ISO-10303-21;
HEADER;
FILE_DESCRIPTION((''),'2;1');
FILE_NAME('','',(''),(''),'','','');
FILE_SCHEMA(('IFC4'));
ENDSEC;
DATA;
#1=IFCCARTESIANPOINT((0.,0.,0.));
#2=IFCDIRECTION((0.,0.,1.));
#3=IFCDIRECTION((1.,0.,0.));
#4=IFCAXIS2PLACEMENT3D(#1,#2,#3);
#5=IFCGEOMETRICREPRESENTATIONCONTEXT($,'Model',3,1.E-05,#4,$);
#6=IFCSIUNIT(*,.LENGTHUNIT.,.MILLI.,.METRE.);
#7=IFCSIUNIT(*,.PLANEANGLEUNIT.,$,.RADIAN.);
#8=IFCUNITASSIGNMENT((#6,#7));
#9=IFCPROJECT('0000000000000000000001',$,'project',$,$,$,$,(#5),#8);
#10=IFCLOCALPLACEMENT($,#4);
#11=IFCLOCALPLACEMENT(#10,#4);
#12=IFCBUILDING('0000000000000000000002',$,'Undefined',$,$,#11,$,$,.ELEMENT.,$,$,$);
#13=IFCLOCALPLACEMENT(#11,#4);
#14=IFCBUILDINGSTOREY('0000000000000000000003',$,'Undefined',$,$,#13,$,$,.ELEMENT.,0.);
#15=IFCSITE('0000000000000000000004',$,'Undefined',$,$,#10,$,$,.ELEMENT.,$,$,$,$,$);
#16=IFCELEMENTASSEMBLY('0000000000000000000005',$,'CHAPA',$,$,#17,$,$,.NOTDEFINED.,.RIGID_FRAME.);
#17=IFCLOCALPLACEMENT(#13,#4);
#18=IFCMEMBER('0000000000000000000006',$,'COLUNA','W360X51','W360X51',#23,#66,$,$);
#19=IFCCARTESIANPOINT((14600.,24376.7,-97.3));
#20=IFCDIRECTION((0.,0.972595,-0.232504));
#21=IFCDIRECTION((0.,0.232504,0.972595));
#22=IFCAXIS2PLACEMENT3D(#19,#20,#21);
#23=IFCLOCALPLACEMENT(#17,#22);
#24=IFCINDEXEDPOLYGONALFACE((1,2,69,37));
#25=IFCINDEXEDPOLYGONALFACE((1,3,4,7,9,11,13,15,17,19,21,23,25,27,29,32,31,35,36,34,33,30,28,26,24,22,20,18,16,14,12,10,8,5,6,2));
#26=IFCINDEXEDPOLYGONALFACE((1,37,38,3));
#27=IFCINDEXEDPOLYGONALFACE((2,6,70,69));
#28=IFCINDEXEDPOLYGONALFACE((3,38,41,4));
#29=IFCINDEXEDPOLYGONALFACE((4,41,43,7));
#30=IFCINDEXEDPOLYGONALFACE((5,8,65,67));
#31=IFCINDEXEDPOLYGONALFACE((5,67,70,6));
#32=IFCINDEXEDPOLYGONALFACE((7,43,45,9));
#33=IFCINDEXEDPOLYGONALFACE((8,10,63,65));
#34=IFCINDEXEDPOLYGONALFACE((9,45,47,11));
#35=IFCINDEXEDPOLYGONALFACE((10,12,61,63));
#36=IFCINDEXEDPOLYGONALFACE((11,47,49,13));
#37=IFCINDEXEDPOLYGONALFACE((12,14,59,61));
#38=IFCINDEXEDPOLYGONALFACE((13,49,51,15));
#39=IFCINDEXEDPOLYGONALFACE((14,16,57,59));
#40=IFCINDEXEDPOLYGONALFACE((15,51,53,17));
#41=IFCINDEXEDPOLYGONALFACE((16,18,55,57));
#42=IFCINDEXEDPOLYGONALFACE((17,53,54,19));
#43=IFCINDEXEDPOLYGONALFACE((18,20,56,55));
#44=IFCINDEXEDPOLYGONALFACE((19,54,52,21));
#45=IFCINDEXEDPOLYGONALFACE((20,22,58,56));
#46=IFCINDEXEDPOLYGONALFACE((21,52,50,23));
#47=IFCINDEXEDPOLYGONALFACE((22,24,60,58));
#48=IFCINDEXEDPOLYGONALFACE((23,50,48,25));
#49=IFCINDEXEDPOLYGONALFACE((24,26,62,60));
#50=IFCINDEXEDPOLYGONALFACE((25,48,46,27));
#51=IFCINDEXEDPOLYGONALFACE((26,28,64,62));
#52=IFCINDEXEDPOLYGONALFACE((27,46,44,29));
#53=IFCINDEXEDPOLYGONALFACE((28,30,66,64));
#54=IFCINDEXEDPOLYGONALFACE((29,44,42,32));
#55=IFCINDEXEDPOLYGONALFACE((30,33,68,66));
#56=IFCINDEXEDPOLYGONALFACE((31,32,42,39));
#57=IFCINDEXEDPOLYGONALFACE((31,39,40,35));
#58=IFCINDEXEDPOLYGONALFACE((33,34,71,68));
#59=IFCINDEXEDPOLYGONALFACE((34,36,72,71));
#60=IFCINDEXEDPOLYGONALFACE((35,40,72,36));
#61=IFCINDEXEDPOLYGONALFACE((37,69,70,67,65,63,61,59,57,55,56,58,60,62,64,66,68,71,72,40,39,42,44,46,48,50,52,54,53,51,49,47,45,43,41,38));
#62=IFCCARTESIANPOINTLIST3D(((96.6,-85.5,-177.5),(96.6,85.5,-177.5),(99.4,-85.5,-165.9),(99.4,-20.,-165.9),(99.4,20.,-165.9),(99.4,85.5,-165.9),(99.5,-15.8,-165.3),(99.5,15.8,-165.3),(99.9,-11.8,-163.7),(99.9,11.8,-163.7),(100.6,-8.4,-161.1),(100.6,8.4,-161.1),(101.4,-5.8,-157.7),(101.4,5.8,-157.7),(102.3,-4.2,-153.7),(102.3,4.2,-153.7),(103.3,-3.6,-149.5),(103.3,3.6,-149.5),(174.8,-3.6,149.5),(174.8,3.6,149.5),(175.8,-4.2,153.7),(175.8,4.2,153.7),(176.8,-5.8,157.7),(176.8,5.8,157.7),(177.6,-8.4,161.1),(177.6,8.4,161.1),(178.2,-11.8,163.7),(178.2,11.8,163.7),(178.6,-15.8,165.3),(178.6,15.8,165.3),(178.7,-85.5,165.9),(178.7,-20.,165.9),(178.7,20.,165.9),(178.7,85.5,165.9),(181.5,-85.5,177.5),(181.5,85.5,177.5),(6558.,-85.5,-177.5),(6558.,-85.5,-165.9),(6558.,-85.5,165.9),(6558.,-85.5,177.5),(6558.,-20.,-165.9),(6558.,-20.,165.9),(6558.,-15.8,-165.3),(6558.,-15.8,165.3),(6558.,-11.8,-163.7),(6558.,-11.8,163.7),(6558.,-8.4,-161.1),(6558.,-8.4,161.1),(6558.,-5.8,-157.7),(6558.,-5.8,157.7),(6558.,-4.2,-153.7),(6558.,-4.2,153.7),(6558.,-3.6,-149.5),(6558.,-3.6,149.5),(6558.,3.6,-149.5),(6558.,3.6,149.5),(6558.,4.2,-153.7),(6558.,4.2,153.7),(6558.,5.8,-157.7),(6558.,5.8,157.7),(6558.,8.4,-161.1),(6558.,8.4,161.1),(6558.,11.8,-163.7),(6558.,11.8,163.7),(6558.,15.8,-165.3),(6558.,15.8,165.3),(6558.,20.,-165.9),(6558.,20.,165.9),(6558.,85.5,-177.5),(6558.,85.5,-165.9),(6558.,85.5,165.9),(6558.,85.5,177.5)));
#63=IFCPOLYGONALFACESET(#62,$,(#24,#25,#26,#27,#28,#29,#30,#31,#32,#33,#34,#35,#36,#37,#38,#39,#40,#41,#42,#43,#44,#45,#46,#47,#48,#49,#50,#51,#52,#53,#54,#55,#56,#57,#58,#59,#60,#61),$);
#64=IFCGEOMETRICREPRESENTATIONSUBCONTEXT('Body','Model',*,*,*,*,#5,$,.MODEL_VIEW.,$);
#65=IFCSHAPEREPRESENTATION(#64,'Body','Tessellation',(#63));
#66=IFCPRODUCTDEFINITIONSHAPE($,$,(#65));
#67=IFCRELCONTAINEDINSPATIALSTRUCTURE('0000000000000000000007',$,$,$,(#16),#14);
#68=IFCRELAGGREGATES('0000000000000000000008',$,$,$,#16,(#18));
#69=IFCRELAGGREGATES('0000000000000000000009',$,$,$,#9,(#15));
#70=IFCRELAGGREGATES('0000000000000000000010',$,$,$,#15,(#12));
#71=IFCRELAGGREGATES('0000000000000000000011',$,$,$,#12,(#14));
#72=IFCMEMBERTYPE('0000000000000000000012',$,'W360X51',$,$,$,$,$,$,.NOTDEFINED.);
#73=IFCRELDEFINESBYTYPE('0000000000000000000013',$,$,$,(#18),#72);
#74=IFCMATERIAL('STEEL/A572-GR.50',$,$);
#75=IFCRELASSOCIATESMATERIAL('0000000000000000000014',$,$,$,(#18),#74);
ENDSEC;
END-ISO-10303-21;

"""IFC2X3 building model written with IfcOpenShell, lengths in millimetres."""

from ifc_helpers import new_model, si_unit, frame, origin_with_axes, origin_2d_with_axis, place, context, subcontext, project, spatial, i_section, extrude, clip, halfspace, material, type_object, element, aggregate, save


model = new_model("IFC2X3")

# Units and contexts
model_context = context("Model", 3, precision=1e-05, world=origin_with_axes())
body_context = subcontext(model_context, "Body", "Model", "MODEL_VIEW")
ifc_project = project(units=[si_unit("LENGTHUNIT", "METRE", prefix="MILLI"), si_unit("PLANEANGLEUNIT", "RADIAN")], contexts=[model_context])

# Site, building, storey
site_placement = place(None, origin_with_axes())
site = spatial("IfcSite", under=ifc_project, at=site_placement, Name="Undefined", CompositionType="ELEMENT")
building_placement = place(site_placement, origin_with_axes())
building = spatial("IfcBuilding", under=site, at=building_placement, Name="Undefined", CompositionType="ELEMENT")
storey_placement = place(building_placement, origin_with_axes())
storey = spatial("IfcBuildingStorey", under=building, at=storey_placement, Name="Undefined", CompositionType="ELEMENT", Elevation=0.0)

# Element assembly, member
assembly_1_placement = place(storey_placement, origin_with_axes())
assembly_1 = element("IfcElementAssembly", 1, at=assembly_1_placement, inside=storey, Name="CHAPA", AssemblyPlace="NOTDEFINED", PredefinedType="RIGID_FRAME")
ifc_material_1 = material(Name="STEEL/A572-GR.50")
member_type = type_object("IfcMemberType", Name="W360X51", PredefinedType="NOTDEFINED")
member_placement = place(assembly_1_placement, frame((14600.0, 24376.7, -97.3), z_axis=(0.0, 0.972595, -0.232504), x_axis=(0.0, 0.232504, 0.972595)))
member = element("IfcMember", 2, at=member_placement, type_object=member_type, material=ifc_material_1, Name="COLUNA", Description="W360X51", ObjectType="W360X51", context=body_context, shape_type="Clipping", body=[
    clip(clip(extrude(i_section(OverallWidth=171.0, OverallDepth=355.0, WebThickness=7.2, FlangeThickness=11.6, FilletRadius=16.4, at=origin_2d_with_axis()), frame((6558.0, 0.0, 0.0), z_axis=(-1.0, 0.0, 0.0), x_axis=(0.0, -1.0, 0.0)), (0.0, 0.0, 1.0), 6542.9), halfspace(frame((94.5, -85.5, -186.3), z_axis=(-0.972595, 0.0, 0.232504), x_axis=(0.0, 1.0, 0.0)), False)), halfspace(frame((96.6, 0.0, -177.5), z_axis=(0.972595, 0.0, -0.232504), x_axis=(0.0, -1.0, 0.0)), True)),
])

aggregate(assembly_1, [member])

save(model, "model.ifc")
